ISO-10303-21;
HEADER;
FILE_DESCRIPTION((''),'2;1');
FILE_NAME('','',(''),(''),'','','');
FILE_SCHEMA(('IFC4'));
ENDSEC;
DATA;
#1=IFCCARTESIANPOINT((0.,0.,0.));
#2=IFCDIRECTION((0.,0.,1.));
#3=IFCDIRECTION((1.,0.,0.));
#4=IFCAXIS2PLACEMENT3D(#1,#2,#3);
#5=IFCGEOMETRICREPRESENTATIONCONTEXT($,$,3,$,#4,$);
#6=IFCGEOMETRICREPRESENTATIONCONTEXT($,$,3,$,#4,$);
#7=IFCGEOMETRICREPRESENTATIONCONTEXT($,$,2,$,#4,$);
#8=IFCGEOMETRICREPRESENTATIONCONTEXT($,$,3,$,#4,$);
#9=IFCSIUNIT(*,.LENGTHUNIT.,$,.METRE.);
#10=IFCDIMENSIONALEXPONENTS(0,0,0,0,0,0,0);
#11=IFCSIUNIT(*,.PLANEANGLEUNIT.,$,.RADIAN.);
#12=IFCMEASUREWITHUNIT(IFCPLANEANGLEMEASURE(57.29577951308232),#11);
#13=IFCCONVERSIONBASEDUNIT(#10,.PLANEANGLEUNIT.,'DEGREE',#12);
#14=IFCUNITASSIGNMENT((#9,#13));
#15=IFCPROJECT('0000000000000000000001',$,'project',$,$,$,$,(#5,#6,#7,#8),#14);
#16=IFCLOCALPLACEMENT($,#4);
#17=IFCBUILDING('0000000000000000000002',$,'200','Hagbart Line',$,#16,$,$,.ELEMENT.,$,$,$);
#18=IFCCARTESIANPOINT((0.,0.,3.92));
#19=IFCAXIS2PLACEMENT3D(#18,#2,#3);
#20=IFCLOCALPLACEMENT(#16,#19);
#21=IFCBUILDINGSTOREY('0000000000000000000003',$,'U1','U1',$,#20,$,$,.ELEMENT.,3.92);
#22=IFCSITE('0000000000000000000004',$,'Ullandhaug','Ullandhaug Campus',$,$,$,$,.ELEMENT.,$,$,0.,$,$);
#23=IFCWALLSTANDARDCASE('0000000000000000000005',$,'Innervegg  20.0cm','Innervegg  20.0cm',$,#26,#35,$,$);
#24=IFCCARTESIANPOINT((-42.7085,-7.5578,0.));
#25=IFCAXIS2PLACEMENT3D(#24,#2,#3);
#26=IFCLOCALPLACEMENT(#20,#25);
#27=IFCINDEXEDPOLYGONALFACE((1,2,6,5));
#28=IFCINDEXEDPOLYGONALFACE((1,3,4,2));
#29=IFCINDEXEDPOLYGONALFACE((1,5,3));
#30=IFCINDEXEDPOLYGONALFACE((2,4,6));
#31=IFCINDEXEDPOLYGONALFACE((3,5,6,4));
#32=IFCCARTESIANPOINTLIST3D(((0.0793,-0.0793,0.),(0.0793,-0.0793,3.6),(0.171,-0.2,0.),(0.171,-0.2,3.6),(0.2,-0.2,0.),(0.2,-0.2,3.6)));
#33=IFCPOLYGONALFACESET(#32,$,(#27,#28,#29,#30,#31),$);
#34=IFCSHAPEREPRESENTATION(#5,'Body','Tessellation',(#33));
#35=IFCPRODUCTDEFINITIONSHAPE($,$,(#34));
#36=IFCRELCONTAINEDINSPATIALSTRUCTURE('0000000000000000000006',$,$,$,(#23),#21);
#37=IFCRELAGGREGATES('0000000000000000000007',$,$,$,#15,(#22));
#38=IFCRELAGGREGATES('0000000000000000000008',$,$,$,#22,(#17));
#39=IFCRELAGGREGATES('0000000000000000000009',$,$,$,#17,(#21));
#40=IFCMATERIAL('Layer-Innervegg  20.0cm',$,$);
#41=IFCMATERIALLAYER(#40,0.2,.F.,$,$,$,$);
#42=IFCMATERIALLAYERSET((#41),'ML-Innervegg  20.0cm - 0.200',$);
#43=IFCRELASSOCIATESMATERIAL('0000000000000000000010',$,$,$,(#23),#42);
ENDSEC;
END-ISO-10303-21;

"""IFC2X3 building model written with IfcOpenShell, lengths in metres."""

from ifc_helpers import new_model, entity, si_unit, converted_unit, frame, origin_with_axes, place, context, project, spatial, polyline, outline, extrude, material, layer, layer_set, layer_usage, element, save


model = new_model("IFC2X3")

# Units and contexts
context_of_model_1 = context(None, 3, world=origin_with_axes())
context_of_model_2 = context(None, 3, world=origin_with_axes())
context_of_model_3 = context(None, 2, world=origin_with_axes())
context_of_model_4 = context(None, 3, world=origin_with_axes())
ifc_project = project(units=[si_unit("LENGTHUNIT", "METRE"), converted_unit("PLANEANGLEUNIT", "DEGREE", entity("IfcPlaneAngleMeasure", 57.29577951308232), si_unit("PLANEANGLEUNIT", "RADIAN"), dimensions=[0, 0, 0, 0, 0, 0, 0])], contexts=[context_of_model_1, context_of_model_2, context_of_model_3, context_of_model_4])

# Site, building, storey
site = spatial("IfcSite", under=ifc_project, Name="Ullandhaug", Description="Ullandhaug Campus", CompositionType="ELEMENT", RefElevation=0.0)
building_placement = place(None, origin_with_axes())
building = spatial("IfcBuilding", under=site, at=building_placement, Name="200", Description="Hagbart Line", CompositionType="ELEMENT")
storey_placement = place(building_placement, frame((0.0, 0.0, 3.92), z_axis=(0.0, 0.0, 1.0), x_axis=(1.0, 0.0, 0.0)))
storey = spatial("IfcBuildingStorey", under=building, at=storey_placement, Name="U1", Description="U1", CompositionType="ELEMENT", Elevation=3.92)

# Shared definitions
ifc_material_1 = material(Name="Layer-Innervegg  20.0cm")
ifc_layer_1 = layer(ifc_material_1, 0.2, ventilated=False)
ifc_layer_set_1 = layer_set([ifc_layer_1], Name="ML-Innervegg  20.0cm - 0.200")
ifc_layer_usage_1 = layer_usage(ifc_layer_set_1, "AXIS2", "POSITIVE", 0.0)

# Wall
wall_1_placement = place(storey_placement, frame((-42.7085, -7.5578, 0.0), z_axis=(0.0, 0.0, 1.0), x_axis=(1.0, 0.0, 0.0)))
element("IfcWallStandardCase", 1, at=wall_1_placement, inside=storey, material=ifc_layer_usage_1, Name="Innervegg  20.0cm", Description="Innervegg  20.0cm", context=context_of_model_1, shape_type="SweptSolid", body=[
    extrude(outline(polyline([(0.0, 0.0), (0.019, 0.0), (0.171, 0.2), (0.2, 0.2), (0.0, 0.0)])), frame((0.0, 0.0, 0.0), z_axis=(0.0, 0.0, -1.0), x_axis=(1.0, 0.0, 0.0)), (0.0, 0.0, -1.0), 3.6),
])

save(model, "model.ifc")
